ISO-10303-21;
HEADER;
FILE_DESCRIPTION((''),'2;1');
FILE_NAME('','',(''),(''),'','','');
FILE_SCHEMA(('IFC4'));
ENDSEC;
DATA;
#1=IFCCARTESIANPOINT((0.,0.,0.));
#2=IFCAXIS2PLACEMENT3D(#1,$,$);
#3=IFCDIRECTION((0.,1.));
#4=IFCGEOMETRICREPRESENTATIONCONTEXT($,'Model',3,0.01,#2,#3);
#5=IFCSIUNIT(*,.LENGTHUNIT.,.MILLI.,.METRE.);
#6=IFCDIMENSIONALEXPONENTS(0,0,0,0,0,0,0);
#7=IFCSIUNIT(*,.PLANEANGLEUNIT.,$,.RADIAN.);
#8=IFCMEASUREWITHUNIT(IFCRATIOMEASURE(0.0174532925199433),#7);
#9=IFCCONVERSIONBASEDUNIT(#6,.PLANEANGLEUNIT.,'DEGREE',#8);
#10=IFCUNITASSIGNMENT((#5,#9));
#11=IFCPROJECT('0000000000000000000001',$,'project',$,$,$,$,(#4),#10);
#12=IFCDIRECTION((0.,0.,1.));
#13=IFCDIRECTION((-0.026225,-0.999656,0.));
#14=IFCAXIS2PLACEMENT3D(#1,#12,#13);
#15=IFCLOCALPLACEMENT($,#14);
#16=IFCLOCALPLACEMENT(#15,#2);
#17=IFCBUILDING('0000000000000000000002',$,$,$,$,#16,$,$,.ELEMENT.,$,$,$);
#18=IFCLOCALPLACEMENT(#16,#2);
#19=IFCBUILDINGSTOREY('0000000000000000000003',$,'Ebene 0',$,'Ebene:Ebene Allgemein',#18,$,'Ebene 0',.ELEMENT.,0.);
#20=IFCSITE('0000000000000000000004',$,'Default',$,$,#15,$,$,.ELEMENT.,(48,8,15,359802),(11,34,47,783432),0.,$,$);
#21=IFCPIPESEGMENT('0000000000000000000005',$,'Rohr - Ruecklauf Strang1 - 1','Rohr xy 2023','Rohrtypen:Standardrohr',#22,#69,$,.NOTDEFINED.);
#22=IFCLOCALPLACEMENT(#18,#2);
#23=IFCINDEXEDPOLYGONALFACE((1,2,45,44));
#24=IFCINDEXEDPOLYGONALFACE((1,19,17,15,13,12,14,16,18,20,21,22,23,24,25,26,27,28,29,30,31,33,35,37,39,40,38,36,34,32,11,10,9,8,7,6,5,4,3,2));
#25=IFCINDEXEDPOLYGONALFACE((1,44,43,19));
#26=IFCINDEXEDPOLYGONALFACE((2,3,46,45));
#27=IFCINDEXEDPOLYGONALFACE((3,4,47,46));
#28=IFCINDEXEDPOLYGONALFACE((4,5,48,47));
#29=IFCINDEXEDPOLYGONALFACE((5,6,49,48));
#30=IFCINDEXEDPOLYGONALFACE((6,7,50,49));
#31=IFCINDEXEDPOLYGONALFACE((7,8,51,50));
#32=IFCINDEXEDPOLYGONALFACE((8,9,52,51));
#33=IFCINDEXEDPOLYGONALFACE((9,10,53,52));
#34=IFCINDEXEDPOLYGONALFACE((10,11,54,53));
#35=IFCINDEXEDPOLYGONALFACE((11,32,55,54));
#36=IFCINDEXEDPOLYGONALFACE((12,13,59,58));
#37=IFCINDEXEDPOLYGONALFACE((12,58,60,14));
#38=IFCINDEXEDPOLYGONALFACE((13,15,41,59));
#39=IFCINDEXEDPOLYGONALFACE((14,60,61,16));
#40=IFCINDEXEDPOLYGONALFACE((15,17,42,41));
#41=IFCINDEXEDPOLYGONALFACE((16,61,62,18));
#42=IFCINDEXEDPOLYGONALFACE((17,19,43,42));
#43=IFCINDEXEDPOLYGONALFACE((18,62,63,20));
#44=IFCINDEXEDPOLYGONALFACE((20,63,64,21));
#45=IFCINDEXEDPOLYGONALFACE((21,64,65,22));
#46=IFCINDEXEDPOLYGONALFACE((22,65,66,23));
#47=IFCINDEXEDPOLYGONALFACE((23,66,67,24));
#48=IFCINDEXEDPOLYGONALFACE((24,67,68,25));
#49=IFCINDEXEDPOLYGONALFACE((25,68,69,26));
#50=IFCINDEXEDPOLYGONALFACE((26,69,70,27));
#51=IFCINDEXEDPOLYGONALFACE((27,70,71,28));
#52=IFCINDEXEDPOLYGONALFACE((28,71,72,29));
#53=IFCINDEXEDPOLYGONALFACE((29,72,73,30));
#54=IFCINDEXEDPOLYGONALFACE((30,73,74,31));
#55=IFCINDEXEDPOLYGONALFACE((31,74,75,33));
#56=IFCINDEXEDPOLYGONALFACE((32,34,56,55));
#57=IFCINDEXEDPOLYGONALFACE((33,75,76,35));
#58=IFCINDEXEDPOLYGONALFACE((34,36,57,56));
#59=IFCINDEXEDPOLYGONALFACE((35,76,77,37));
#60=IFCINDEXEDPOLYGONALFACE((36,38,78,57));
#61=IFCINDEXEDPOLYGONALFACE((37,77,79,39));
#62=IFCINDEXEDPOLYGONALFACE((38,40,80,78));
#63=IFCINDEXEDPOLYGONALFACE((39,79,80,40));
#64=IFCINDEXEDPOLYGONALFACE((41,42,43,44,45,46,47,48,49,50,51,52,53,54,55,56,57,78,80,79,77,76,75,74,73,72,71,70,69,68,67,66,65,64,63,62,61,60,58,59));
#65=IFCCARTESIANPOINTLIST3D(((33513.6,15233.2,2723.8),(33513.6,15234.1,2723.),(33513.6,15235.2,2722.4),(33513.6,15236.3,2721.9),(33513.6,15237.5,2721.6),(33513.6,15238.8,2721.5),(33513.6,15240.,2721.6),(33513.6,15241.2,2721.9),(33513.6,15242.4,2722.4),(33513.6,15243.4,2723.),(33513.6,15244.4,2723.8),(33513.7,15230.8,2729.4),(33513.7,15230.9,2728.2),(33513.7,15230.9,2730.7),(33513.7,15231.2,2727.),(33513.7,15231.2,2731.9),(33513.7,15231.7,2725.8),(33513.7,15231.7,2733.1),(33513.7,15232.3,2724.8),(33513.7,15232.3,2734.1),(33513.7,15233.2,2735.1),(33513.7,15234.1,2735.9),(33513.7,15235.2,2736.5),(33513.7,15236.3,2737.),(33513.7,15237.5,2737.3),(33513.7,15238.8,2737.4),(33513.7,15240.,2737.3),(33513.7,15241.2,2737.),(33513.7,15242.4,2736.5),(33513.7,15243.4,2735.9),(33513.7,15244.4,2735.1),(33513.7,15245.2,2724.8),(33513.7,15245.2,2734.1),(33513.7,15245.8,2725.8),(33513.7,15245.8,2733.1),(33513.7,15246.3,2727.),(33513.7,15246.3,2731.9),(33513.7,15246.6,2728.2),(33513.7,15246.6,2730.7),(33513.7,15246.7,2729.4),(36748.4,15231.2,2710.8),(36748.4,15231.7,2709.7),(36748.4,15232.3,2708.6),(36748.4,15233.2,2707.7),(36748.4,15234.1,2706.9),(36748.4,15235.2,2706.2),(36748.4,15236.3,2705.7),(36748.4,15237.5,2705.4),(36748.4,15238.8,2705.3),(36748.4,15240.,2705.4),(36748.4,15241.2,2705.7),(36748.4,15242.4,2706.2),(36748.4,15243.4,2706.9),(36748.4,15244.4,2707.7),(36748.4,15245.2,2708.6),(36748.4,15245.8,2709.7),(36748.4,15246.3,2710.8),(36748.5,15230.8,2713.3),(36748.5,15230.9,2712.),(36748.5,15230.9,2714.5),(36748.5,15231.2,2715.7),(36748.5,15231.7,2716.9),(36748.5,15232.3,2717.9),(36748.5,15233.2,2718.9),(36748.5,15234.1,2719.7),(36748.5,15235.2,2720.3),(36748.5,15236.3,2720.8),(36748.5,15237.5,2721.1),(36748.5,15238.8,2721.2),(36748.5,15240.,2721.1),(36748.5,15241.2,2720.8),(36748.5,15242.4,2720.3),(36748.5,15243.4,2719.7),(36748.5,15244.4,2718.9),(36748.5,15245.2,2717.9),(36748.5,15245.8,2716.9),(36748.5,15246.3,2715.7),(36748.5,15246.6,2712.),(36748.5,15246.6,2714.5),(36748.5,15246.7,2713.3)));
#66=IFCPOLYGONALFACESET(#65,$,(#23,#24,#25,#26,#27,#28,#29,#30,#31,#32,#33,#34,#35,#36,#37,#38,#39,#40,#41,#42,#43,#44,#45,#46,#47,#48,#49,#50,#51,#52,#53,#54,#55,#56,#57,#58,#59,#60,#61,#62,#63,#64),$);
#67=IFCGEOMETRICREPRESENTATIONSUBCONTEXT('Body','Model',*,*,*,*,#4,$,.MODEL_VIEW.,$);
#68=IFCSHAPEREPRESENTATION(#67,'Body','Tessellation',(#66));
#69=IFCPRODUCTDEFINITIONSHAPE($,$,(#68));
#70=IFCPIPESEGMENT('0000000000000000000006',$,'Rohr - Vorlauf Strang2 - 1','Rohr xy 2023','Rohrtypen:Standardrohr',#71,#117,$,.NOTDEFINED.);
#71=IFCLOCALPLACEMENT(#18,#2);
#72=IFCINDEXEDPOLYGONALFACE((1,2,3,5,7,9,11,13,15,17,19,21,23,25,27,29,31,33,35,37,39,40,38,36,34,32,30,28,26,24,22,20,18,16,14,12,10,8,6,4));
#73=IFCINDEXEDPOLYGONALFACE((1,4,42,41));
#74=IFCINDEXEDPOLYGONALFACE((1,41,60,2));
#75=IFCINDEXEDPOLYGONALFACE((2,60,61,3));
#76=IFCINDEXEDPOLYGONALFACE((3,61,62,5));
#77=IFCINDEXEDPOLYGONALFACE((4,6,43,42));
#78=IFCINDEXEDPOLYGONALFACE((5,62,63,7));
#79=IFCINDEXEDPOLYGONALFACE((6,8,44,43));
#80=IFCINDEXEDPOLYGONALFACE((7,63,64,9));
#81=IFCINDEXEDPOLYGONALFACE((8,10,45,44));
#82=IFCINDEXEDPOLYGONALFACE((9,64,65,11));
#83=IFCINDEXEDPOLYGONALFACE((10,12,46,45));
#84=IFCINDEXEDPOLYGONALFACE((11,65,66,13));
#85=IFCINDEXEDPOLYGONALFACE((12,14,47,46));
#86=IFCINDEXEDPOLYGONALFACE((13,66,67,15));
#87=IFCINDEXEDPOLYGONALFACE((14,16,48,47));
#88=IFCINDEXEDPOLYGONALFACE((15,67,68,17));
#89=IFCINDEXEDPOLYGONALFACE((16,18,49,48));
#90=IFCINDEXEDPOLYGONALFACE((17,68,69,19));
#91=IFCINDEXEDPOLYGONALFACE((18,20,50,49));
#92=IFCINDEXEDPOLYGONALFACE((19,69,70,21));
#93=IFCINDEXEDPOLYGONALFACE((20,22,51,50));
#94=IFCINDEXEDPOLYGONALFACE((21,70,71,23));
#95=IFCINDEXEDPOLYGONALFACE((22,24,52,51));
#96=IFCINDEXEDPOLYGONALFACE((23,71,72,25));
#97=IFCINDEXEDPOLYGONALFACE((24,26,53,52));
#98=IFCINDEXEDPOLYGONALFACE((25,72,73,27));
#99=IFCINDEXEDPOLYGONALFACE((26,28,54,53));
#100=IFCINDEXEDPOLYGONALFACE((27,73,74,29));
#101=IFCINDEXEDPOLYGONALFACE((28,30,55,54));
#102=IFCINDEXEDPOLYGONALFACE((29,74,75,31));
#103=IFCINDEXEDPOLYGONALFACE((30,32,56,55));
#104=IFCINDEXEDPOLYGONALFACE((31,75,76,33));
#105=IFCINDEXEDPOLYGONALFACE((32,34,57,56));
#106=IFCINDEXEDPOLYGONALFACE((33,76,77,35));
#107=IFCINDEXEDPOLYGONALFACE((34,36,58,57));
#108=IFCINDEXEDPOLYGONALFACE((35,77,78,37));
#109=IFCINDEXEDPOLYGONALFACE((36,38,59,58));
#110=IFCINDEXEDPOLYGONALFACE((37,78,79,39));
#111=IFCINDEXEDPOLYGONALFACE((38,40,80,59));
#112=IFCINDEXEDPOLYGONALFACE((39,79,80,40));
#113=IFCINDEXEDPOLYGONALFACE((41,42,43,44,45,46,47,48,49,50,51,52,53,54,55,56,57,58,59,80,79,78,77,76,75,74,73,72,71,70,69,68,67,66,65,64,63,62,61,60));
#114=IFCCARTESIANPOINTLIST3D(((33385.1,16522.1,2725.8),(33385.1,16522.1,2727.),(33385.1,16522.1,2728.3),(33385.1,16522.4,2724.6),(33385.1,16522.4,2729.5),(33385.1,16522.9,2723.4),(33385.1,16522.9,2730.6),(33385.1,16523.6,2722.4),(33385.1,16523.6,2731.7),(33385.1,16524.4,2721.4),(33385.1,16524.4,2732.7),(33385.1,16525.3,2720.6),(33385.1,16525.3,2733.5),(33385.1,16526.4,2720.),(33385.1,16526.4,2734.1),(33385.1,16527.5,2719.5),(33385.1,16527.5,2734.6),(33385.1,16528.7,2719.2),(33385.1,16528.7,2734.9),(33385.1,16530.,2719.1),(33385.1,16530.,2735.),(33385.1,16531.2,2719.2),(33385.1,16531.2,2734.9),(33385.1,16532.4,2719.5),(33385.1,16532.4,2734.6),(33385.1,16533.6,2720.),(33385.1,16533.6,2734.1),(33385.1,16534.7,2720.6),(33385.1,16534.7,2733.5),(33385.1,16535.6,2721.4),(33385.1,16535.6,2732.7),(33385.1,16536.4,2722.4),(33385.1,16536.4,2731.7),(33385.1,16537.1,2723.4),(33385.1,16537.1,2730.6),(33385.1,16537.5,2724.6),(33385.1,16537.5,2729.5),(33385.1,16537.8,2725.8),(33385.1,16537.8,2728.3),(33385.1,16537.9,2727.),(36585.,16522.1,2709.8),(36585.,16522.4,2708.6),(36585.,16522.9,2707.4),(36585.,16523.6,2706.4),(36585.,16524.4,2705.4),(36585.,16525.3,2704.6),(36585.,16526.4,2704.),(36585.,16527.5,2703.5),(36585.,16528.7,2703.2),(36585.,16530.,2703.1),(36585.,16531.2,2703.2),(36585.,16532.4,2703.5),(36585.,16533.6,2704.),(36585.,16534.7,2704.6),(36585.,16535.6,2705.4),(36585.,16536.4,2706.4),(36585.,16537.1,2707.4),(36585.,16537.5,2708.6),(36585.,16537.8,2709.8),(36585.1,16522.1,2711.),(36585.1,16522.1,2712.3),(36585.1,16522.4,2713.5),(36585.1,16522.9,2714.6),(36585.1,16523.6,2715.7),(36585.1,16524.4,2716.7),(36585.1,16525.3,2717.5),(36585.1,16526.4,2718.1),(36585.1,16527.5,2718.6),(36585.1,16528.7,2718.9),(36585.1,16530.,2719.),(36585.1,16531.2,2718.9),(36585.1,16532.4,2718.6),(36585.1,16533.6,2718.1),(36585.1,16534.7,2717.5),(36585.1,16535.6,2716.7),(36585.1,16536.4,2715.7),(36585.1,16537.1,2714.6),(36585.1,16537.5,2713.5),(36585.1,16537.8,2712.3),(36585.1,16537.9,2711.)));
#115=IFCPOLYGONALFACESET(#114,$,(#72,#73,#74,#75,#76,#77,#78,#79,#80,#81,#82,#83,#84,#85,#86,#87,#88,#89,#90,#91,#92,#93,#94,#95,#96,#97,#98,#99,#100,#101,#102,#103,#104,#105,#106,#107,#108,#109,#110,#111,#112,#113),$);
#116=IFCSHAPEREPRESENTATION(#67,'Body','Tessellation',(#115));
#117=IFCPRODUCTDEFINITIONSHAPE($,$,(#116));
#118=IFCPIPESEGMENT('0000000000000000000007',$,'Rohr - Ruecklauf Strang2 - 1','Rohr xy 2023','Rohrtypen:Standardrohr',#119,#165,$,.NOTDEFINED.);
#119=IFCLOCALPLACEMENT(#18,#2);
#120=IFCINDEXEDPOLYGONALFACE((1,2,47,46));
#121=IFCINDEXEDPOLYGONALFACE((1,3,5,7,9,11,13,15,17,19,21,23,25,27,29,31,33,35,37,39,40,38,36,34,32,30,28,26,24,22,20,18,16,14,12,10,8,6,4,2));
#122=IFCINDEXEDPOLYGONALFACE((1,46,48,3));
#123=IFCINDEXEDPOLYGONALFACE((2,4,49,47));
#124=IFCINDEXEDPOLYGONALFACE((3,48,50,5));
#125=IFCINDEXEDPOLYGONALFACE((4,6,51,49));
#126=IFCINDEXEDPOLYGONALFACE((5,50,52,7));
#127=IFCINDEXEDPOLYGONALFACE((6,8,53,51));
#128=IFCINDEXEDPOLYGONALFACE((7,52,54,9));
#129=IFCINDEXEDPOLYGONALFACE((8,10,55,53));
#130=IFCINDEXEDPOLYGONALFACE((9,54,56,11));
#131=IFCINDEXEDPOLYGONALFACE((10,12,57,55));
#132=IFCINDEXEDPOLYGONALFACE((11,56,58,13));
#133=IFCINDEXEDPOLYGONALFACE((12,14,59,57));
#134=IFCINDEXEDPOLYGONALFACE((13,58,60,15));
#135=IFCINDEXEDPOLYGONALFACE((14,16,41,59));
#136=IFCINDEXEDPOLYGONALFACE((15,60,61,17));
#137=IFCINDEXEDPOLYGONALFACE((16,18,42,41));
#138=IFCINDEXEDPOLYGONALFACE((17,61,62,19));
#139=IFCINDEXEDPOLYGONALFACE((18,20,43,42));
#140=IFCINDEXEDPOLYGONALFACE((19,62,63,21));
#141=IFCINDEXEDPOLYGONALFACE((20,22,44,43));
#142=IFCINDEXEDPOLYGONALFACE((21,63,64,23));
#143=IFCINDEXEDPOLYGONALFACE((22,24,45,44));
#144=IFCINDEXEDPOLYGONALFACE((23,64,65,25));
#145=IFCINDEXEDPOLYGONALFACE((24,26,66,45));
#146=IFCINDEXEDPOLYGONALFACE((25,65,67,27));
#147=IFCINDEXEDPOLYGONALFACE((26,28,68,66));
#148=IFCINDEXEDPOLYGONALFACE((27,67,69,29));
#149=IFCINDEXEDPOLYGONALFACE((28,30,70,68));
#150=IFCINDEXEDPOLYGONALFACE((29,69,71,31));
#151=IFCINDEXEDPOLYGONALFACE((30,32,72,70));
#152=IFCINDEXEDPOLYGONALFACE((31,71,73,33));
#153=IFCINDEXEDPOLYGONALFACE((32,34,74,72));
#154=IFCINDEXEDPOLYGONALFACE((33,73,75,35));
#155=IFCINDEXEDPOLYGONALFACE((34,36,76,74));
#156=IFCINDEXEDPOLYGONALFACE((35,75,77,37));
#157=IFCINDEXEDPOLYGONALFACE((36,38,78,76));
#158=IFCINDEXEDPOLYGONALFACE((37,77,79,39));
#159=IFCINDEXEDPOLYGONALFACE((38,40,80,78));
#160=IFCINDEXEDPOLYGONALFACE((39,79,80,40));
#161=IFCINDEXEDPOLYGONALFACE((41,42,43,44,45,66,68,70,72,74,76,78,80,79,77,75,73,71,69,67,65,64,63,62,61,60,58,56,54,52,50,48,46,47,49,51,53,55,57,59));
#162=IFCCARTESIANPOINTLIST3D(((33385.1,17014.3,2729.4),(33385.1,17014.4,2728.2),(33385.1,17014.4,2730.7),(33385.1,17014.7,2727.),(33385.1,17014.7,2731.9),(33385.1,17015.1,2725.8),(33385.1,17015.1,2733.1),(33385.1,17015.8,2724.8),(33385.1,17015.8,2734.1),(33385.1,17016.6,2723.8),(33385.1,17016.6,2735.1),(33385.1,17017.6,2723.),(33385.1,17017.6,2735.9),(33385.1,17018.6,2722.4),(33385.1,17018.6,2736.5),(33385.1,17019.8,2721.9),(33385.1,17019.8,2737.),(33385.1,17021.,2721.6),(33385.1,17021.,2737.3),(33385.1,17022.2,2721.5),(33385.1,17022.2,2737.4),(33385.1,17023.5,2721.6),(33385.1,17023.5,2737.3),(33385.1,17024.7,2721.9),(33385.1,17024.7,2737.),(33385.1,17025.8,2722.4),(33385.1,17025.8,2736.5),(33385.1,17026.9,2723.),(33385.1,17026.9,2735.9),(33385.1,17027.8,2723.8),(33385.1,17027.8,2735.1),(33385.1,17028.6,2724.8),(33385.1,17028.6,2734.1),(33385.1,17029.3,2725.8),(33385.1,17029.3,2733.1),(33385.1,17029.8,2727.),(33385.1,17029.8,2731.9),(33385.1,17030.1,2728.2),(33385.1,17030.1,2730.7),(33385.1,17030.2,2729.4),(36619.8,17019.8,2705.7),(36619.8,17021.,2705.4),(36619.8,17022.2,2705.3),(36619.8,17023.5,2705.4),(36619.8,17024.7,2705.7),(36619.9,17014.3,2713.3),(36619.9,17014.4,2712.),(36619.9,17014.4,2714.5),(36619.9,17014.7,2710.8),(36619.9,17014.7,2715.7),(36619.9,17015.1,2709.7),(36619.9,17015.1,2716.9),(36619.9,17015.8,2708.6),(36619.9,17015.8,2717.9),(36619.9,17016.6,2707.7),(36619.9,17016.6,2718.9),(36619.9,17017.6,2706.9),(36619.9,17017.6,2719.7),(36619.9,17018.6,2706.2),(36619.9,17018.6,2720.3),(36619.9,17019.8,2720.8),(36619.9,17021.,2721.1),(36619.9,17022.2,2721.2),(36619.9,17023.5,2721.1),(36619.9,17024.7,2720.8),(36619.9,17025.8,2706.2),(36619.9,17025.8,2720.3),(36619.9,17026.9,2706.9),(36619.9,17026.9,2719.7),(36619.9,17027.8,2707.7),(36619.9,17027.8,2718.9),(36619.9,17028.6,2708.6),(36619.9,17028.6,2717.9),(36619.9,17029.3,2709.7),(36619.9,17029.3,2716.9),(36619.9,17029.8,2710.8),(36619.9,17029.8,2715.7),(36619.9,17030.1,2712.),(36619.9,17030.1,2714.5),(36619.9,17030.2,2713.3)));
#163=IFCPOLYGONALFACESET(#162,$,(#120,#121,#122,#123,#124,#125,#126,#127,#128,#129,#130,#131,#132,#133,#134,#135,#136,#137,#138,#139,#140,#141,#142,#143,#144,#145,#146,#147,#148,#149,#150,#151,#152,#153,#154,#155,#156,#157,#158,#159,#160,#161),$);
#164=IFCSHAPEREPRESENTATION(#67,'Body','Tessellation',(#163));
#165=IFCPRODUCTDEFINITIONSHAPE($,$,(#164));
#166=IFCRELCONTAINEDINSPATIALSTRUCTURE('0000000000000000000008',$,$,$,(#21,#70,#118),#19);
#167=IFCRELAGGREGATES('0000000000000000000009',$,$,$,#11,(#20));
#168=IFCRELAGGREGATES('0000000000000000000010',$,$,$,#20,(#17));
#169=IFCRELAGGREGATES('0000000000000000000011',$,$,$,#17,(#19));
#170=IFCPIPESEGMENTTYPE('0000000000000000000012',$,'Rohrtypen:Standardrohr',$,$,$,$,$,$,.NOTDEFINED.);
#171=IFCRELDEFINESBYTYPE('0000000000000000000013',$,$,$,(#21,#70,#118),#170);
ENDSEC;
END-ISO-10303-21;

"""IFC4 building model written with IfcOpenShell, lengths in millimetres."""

from ifc_helpers import new_model, entity, si_unit, converted_unit, direction, frame, origin, place, context, subcontext, project, spatial, indexed_curve, outline, extrude, type_object, element, save


model = new_model("IFC4")

# Units and contexts
model_context = context("Model", 3, precision=0.01, world=origin(), true_north=direction((0.0, 1.0)))
body_context = subcontext(model_context, "Body", "Model", "MODEL_VIEW")
ifc_project = project(units=[si_unit("LENGTHUNIT", "METRE", prefix="MILLI"), converted_unit("PLANEANGLEUNIT", "DEGREE", entity("IfcRatioMeasure", 0.0174532925199433), si_unit("PLANEANGLEUNIT", "RADIAN"), dimensions=[0, 0, 0, 0, 0, 0, 0])], contexts=[model_context])

# Site, building, storey
site_placement = place(None, frame((0.0, 0.0, 0.0), z_axis=(0.0, 0.0, 1.0), x_axis=(-0.026225, -0.999656, 0.0)))
site = spatial("IfcSite", under=ifc_project, at=site_placement, Name="Default", CompositionType="ELEMENT", RefLatitude=(48, 8, 15, 359802), RefLongitude=(11, 34, 47, 783432), RefElevation=0.0)
building_placement = place(site_placement, origin())
building = spatial("IfcBuilding", under=site, at=building_placement, CompositionType="ELEMENT")
storey_placement = place(building_placement, origin())
storey = spatial("IfcBuildingStorey", under=building, at=storey_placement, Name="Ebene 0", ObjectType="Ebene:Ebene Allgemein", LongName="Ebene 0", CompositionType="ELEMENT", Elevation=0.0)

# Pipe segments
pipe_segment_type = type_object("IfcPipeSegmentType", Name="Rohrtypen:Standardrohr", PredefinedType="NOTDEFINED")
pipe_segment_1_placement = place(storey_placement, origin())
element("IfcPipeSegment", 1, at=pipe_segment_1_placement, inside=storey, type_object=pipe_segment_type, Name="Rohr - Ruecklauf Strang1 - 1", Description="Rohr xy 2023", ObjectType="Rohrtypen:Standardrohr", PredefinedType="NOTDEFINED", context=body_context, shape_type="SweptSolid", body=[
    extrude(outline(indexed_curve([(7.9, 0.0), (7.8, 1.2), (7.6, 2.5), (7.1, 3.6), (6.4, 4.7), (5.6, 5.6), (4.7, 6.4), (3.6, 7.1), (2.5, 7.6), (1.2, 7.8), (0.0, 7.9), (-1.2, 7.8), (-2.5, 7.6), (-3.6, 7.1), (-4.7, 6.4), (-5.6, 5.6), (-6.4, 4.7), (-7.1, 3.6), (-7.6, 2.5), (-7.8, 1.2), (-7.9, 0.0), (-7.8, -1.2), (-7.6, -2.5), (-7.1, -3.6), (-6.4, -4.7), (-5.6, -5.6), (-4.7, -6.4), (-3.6, -7.1), (-2.5, -7.6), (-1.2, -7.8), (0.0, -7.9), (1.2, -7.8), (2.5, -7.6), (3.6, -7.1), (4.7, -6.4), (5.6, -5.6), (6.4, -4.7), (7.1, -3.6), (7.6, -2.5), (7.8, -1.2), (7.9, 0.0)], self_intersect=False)), frame((36748.5, 15238.8, 2713.3), z_axis=(-0.999988, 0.0, 0.005), x_axis=(0.0, 1.0, 0.0)), (0.0, 0.0, 1.0), 3234.8),
])
pipe_segment_2_placement = place(storey_placement, origin())
element("IfcPipeSegment", 2, at=pipe_segment_2_placement, inside=storey, type_object=pipe_segment_type, Name="Rohr - Vorlauf Strang2 - 1", Description="Rohr xy 2023", ObjectType="Rohrtypen:Standardrohr", PredefinedType="NOTDEFINED", context=body_context, shape_type="SweptSolid", body=[
    extrude(outline(indexed_curve([(7.9, 0.0), (7.8, 1.2), (7.6, 2.5), (7.1, 3.6), (6.4, 4.7), (5.6, 5.6), (4.7, 6.4), (3.6, 7.1), (2.5, 7.6), (1.2, 7.8), (0.0, 7.9), (-1.2, 7.8), (-2.5, 7.6), (-3.6, 7.1), (-4.7, 6.4), (-5.6, 5.6), (-6.4, 4.7), (-7.1, 3.6), (-7.6, 2.5), (-7.8, 1.2), (-7.9, 0.0), (-7.8, -1.2), (-7.6, -2.5), (-7.1, -3.6), (-6.4, -4.7), (-5.6, -5.6), (-4.7, -6.4), (-3.6, -7.1), (-2.5, -7.6), (-1.2, -7.8), (0.0, -7.9), (1.2, -7.8), (2.5, -7.6), (3.6, -7.1), (4.7, -6.4), (5.6, -5.6), (6.4, -4.7), (7.1, -3.6), (7.6, -2.5), (7.8, -1.2), (7.9, 0.0)], self_intersect=False)), frame((36585.1, 16530.0, 2711.0), z_axis=(-0.999988, 0.0, 0.005), x_axis=(0.0, 1.0, 0.0)), (0.0, 0.0, 1.0), 3200.0),
])
pipe_segment_3_placement = place(storey_placement, origin())
element("IfcPipeSegment", 3, at=pipe_segment_3_placement, inside=storey, type_object=pipe_segment_type, Name="Rohr - Ruecklauf Strang2 - 1", Description="Rohr xy 2023", ObjectType="Rohrtypen:Standardrohr", PredefinedType="NOTDEFINED", context=body_context, shape_type="SweptSolid", body=[
    extrude(outline(indexed_curve([(7.9, 0.0), (7.8, 1.2), (7.6, 2.5), (7.1, 3.6), (6.4, 4.7), (5.6, 5.6), (4.7, 6.4), (3.6, 7.1), (2.5, 7.6), (1.2, 7.8), (0.0, 7.9), (-1.2, 7.8), (-2.5, 7.6), (-3.6, 7.1), (-4.7, 6.4), (-5.6, 5.6), (-6.4, 4.7), (-7.1, 3.6), (-7.6, 2.5), (-7.8, 1.2), (-7.9, 0.0), (-7.8, -1.2), (-7.6, -2.5), (-7.1, -3.6), (-6.4, -4.7), (-5.6, -5.6), (-4.7, -6.4), (-3.6, -7.1), (-2.5, -7.6), (-1.2, -7.8), (0.0, -7.9), (1.2, -7.8), (2.5, -7.6), (3.6, -7.1), (4.7, -6.4), (5.6, -5.6), (6.4, -4.7), (7.1, -3.6), (7.6, -2.5), (7.8, -1.2), (7.9, 0.0)], self_intersect=False)), frame((36619.9, 17022.2, 2713.3), z_axis=(-0.999988, 0.0, 0.005), x_axis=(0.0, 1.0, 0.0)), (0.0, 0.0, 1.0), 3234.8),
])

save(model, "model.ifc")
